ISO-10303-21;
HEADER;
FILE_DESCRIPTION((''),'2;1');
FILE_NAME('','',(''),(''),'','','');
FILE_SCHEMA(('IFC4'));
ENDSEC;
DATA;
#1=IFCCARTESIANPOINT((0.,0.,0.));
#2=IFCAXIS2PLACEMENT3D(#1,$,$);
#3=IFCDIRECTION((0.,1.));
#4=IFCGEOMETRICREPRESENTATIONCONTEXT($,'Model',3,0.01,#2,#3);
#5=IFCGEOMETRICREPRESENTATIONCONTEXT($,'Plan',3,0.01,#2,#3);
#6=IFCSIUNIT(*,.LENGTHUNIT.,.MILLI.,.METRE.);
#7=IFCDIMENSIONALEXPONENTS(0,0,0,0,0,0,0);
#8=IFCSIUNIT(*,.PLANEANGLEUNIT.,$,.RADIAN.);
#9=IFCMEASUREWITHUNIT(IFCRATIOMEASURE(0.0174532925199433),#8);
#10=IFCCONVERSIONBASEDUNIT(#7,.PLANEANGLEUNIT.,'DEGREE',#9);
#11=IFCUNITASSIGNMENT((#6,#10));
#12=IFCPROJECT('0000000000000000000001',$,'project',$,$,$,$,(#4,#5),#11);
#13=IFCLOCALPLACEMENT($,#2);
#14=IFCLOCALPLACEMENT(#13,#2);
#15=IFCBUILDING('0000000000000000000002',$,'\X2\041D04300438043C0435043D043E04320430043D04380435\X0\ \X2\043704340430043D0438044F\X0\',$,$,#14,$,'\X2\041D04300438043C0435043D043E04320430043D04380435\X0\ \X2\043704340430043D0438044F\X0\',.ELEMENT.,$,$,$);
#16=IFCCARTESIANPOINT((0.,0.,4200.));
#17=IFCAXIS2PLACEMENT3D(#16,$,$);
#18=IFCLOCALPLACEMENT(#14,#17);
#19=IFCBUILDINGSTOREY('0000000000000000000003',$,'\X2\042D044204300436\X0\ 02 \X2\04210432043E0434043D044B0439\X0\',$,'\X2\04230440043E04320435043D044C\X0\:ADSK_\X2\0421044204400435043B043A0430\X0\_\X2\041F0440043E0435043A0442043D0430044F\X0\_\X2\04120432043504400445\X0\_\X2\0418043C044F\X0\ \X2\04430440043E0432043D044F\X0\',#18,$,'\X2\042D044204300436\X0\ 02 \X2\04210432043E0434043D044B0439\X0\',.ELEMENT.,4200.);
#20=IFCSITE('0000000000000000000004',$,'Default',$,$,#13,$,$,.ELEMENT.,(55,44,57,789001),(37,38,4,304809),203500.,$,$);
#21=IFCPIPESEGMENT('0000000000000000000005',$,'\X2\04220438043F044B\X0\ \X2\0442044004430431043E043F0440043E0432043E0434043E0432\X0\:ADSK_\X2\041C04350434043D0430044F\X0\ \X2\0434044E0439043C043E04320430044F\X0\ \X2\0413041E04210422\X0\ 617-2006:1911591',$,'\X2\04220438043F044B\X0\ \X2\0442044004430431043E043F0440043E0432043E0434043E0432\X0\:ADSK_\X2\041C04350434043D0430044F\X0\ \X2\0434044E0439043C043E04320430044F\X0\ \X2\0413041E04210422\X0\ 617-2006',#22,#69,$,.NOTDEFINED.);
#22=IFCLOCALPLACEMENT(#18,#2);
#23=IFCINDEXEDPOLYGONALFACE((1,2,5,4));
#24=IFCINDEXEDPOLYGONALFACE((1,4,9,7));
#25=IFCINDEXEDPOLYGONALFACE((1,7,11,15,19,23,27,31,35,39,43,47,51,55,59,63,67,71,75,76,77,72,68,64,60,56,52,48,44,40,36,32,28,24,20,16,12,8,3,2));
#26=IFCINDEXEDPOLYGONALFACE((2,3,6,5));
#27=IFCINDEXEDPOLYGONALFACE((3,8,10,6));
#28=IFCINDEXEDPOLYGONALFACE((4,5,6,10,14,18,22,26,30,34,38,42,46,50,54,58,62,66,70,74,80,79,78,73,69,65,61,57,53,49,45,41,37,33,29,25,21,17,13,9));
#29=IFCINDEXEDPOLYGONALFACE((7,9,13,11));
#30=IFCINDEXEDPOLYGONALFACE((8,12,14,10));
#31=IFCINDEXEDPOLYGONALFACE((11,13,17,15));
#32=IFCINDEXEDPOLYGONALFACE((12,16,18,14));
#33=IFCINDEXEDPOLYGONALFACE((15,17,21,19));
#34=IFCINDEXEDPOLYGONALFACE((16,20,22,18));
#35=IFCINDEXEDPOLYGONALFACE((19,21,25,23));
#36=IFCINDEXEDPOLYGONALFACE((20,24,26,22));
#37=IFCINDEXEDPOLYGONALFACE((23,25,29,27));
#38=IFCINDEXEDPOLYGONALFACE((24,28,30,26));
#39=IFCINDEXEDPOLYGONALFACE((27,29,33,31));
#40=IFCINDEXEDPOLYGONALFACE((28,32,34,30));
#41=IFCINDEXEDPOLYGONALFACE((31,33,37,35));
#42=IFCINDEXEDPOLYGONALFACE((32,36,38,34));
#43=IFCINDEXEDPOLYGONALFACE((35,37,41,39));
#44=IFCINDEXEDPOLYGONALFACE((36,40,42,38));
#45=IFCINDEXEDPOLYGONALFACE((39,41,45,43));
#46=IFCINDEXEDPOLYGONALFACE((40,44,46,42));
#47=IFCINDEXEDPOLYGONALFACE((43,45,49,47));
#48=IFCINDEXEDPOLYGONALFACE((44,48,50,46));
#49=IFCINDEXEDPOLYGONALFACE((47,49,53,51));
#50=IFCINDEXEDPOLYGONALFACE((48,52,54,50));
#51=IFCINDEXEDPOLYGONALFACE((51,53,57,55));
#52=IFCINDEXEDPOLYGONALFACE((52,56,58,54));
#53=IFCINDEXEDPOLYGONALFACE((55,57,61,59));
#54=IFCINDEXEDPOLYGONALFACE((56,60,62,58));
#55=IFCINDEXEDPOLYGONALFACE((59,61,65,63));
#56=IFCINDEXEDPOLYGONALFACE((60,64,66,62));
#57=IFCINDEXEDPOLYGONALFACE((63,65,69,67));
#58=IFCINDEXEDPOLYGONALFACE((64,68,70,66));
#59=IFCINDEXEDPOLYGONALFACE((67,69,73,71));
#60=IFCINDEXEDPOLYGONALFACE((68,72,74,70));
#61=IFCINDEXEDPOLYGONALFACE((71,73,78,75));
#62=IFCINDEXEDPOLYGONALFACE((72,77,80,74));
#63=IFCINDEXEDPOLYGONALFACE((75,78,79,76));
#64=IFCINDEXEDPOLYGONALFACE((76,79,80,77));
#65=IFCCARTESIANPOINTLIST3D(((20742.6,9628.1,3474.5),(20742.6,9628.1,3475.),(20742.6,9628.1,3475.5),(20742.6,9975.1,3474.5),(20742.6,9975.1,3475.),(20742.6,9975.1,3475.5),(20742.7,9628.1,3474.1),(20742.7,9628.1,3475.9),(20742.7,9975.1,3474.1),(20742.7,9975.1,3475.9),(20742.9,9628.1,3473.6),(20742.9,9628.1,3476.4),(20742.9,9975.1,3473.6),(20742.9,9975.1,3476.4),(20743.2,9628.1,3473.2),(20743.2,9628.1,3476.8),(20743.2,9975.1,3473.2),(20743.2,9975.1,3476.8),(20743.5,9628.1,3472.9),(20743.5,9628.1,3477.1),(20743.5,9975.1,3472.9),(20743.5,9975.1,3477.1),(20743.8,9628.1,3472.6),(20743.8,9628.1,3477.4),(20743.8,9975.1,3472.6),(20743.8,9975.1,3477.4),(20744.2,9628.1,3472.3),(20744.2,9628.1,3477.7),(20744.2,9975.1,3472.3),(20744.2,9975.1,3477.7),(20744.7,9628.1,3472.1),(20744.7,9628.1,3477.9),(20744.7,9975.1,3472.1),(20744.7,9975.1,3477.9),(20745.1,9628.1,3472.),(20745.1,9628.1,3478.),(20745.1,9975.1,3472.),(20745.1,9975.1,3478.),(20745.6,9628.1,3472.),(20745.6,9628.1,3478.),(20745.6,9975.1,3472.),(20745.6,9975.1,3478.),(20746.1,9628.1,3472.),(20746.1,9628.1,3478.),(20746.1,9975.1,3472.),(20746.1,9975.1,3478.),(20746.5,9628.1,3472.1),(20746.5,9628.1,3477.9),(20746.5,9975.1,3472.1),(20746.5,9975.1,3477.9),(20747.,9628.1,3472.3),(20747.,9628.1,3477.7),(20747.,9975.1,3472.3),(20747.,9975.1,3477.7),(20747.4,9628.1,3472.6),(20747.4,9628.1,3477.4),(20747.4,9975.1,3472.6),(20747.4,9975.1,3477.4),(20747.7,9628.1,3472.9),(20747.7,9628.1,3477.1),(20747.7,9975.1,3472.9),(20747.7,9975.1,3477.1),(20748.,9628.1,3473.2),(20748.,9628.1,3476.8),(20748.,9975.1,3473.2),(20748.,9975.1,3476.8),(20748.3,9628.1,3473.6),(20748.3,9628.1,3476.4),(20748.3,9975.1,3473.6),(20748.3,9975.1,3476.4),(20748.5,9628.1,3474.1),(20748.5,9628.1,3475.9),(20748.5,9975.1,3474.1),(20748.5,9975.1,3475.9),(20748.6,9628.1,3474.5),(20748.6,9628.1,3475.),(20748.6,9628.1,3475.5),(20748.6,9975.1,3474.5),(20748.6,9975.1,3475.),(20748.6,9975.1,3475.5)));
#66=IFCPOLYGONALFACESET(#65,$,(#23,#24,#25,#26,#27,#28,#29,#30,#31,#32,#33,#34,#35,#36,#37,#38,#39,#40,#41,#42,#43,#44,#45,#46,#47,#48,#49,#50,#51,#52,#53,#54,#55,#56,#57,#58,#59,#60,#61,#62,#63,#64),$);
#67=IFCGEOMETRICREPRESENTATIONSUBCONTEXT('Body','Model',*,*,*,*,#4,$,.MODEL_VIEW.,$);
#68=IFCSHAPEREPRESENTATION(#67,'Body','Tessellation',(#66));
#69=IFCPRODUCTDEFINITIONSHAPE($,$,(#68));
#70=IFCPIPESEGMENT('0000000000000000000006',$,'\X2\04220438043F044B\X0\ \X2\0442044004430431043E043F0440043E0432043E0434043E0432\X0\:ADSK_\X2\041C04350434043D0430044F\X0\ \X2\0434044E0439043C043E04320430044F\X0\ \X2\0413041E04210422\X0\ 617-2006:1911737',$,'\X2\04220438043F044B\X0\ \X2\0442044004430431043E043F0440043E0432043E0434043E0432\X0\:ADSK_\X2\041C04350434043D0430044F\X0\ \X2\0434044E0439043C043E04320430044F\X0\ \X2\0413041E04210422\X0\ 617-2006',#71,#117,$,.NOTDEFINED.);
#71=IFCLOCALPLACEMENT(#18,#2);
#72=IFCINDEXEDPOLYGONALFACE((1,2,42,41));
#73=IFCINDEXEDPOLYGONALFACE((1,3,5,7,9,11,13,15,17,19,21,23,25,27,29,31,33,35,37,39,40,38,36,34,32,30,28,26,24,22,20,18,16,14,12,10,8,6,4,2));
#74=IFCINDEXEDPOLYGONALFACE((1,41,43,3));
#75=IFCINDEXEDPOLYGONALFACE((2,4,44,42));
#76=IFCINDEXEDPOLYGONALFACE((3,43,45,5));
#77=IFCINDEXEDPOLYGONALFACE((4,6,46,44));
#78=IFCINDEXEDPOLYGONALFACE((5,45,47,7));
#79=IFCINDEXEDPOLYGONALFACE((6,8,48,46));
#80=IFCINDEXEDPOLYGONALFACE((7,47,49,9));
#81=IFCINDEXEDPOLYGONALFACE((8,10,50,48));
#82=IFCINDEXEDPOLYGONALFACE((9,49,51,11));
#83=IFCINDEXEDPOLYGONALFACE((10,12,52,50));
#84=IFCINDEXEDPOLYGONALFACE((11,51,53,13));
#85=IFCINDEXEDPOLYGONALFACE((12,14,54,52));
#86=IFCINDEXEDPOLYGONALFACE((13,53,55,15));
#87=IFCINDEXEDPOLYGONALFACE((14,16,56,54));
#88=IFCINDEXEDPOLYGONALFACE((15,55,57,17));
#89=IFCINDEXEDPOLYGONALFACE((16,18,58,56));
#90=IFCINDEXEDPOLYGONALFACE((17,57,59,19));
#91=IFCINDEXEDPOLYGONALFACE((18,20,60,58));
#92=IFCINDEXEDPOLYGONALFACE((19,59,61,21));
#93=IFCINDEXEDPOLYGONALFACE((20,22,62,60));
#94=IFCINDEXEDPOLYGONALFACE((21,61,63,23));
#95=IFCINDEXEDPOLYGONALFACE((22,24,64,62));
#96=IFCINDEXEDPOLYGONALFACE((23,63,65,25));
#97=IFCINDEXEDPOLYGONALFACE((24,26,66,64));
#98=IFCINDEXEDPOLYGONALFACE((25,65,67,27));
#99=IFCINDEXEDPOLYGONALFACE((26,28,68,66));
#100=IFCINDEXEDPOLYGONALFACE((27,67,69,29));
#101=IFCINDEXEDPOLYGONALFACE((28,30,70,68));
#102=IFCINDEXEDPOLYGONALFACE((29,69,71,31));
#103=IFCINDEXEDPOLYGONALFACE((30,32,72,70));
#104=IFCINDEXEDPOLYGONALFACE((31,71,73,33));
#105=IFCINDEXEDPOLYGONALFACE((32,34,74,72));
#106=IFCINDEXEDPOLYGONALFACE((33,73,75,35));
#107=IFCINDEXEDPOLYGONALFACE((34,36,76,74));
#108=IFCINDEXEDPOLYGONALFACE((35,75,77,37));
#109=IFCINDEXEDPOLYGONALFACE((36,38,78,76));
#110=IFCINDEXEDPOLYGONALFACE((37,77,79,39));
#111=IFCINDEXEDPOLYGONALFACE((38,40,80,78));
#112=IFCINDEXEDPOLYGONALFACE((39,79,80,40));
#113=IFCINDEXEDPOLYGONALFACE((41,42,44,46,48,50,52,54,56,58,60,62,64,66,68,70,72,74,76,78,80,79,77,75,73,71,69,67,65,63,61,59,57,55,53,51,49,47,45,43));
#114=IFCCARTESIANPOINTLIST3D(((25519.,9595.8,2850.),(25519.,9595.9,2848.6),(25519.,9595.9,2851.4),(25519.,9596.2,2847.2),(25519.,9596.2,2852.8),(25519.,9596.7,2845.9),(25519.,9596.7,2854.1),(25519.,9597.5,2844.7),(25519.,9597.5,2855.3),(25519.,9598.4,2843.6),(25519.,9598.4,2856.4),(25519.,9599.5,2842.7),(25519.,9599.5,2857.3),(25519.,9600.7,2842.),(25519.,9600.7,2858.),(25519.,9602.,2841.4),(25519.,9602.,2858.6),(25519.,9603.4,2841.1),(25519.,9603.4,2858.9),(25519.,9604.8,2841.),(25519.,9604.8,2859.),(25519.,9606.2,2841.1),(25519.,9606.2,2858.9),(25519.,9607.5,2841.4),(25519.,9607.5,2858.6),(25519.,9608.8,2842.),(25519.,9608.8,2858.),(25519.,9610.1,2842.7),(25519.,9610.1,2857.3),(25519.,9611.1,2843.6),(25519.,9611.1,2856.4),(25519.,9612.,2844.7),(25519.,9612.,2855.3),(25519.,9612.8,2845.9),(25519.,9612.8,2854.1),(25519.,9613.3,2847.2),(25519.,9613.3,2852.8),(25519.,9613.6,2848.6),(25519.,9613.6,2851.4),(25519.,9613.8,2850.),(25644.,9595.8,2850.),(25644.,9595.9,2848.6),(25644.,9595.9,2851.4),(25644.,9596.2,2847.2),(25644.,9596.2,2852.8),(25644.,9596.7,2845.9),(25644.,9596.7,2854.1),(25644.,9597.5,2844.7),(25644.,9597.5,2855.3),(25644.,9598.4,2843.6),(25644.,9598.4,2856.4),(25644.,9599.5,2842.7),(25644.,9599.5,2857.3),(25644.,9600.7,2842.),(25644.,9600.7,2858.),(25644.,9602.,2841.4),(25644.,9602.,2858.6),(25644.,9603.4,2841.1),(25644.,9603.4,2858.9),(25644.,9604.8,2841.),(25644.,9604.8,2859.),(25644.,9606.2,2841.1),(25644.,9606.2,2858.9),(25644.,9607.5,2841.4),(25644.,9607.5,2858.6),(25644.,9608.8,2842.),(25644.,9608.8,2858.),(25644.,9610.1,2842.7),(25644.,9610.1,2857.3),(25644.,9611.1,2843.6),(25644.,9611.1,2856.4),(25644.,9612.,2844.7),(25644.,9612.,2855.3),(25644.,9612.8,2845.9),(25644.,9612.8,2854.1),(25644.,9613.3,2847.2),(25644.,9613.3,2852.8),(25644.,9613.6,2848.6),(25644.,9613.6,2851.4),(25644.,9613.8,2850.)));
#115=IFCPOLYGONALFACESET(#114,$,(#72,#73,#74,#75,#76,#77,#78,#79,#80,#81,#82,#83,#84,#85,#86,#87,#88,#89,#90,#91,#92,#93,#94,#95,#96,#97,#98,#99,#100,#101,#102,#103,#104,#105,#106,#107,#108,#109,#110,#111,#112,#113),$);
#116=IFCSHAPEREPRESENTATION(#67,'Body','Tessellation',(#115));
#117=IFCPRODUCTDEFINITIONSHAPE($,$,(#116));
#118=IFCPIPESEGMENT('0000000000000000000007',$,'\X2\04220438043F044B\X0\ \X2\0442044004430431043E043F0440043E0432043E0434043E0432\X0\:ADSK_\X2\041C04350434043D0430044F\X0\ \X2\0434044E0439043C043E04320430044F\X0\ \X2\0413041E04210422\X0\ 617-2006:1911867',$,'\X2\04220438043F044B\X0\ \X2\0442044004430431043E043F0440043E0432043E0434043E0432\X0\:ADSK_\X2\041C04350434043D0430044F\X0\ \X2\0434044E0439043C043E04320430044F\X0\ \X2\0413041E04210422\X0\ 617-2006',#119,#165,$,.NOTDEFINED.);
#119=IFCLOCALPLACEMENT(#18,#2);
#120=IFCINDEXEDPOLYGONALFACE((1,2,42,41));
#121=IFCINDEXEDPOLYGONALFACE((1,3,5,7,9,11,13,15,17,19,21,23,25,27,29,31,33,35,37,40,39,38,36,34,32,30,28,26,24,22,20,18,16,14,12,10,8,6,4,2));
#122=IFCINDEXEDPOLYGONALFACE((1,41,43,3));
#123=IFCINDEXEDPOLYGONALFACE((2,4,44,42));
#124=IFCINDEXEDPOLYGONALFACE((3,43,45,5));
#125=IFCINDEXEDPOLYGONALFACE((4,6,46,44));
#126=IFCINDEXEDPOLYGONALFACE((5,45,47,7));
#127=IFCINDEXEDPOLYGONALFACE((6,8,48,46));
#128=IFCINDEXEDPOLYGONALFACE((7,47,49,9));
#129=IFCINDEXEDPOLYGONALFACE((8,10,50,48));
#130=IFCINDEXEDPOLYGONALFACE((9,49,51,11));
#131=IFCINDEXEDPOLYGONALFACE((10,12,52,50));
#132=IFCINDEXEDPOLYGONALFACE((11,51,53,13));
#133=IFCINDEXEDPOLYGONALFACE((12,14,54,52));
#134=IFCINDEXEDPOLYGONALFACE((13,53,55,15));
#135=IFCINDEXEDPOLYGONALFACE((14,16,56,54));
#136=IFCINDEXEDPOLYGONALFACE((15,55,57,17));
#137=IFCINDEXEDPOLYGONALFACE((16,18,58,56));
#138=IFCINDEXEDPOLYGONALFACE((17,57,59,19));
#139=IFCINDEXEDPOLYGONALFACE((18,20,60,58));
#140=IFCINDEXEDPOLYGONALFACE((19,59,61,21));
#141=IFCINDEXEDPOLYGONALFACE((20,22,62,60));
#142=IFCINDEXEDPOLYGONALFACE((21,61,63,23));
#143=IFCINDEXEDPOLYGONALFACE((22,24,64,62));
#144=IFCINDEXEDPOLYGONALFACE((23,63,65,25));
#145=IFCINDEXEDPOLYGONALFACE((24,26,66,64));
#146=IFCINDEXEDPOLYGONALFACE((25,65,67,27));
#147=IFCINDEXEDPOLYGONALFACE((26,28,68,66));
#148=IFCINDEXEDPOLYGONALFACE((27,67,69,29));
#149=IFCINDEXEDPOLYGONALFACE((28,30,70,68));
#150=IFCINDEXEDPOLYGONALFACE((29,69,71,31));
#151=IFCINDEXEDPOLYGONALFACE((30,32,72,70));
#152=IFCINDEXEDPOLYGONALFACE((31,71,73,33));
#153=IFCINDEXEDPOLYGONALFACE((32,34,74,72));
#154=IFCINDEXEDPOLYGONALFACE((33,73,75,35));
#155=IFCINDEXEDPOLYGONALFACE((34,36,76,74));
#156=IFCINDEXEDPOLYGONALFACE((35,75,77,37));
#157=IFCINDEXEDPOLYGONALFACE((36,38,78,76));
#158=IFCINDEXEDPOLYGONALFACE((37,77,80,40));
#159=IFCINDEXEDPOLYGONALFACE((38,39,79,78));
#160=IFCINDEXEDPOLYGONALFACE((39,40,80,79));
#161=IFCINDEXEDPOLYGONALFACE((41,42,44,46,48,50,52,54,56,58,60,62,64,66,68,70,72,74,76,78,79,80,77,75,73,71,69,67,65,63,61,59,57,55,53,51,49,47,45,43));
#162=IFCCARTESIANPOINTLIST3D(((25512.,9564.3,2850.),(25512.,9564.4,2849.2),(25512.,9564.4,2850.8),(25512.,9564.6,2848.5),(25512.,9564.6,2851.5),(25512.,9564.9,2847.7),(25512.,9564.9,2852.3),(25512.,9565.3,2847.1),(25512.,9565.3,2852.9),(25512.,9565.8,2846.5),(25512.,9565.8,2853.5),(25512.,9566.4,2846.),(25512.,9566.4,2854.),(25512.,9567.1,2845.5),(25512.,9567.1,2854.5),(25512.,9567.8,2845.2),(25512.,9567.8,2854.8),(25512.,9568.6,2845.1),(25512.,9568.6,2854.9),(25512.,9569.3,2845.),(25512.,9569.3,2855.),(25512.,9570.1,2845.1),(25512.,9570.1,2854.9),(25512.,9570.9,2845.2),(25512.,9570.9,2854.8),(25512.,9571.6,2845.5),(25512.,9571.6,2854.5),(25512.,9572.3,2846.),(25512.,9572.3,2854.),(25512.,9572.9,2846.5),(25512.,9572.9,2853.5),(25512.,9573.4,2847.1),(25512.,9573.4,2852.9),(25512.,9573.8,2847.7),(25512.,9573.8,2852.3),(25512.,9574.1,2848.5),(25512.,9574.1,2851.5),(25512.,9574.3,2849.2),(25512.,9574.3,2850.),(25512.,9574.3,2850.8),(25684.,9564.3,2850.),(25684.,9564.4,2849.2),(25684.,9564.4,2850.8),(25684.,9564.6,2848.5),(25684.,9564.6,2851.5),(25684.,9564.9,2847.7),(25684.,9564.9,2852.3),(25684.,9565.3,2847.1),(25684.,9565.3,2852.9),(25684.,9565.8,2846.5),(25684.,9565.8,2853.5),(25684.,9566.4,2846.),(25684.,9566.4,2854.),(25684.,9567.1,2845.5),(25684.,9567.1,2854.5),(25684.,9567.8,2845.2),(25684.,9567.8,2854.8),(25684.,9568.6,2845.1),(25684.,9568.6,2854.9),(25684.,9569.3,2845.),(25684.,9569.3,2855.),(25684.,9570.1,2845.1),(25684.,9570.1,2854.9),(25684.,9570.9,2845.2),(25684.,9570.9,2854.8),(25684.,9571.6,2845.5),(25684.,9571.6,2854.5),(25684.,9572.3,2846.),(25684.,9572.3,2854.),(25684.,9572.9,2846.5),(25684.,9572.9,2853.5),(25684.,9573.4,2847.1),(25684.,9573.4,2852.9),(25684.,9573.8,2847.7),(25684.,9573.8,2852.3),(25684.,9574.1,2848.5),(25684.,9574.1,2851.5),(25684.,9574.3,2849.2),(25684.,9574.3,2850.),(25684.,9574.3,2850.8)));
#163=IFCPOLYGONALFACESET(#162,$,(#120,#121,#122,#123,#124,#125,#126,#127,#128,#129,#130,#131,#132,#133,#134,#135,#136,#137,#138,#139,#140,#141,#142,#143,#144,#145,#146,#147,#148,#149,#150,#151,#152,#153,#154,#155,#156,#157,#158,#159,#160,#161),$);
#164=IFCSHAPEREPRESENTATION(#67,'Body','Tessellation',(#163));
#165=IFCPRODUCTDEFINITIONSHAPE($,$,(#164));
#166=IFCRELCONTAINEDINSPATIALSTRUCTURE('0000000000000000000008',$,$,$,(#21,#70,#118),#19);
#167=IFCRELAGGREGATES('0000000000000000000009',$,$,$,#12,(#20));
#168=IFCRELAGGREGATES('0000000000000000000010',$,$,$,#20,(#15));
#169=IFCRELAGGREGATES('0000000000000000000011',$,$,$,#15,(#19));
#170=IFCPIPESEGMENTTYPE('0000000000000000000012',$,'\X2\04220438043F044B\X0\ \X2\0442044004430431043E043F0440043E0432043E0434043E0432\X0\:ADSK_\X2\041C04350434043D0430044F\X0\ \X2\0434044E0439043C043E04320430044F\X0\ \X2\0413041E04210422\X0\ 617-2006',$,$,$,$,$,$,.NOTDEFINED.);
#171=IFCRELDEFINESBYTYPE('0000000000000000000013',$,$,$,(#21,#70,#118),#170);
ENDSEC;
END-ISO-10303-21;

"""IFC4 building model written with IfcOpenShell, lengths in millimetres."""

from ifc_helpers import new_model, entity, si_unit, converted_unit, direction, frame, origin, place, context, subcontext, project, spatial, indexed_curve, outline, extrude, type_object, element, save


model = new_model("IFC4")

# Units and contexts
model_context = context("Model", 3, precision=0.01, world=origin(), true_north=direction((0.0, 1.0)))
plan_context = context("Plan", 3, precision=0.01, world=origin(), true_north=direction((0.0, 1.0)))
body_context = subcontext(model_context, "Body", "Model", "MODEL_VIEW")
ifc_project = project(units=[si_unit("LENGTHUNIT", "METRE", prefix="MILLI"), converted_unit("PLANEANGLEUNIT", "DEGREE", entity("IfcRatioMeasure", 0.0174532925199433), si_unit("PLANEANGLEUNIT", "RADIAN"), dimensions=[0, 0, 0, 0, 0, 0, 0])], contexts=[model_context, plan_context])

# Site, building, storey
site_placement = place(None, origin())
site = spatial("IfcSite", under=ifc_project, at=site_placement, Name="Default", CompositionType="ELEMENT", RefLatitude=(55, 44, 57, 789001), RefLongitude=(37, 38, 4, 304809), RefElevation=203500.0)
building_placement = place(site_placement, origin())
building = spatial("IfcBuilding", under=site, at=building_placement, Name="Наименование здания", LongName="Наименование здания", CompositionType="ELEMENT")
storey_placement = place(building_placement, frame((0.0, 0.0, 4200.0)))
storey = spatial("IfcBuildingStorey", under=building, at=storey_placement, Name="Этаж 02 Сводный", ObjectType="Уровень:ADSK_Стрелка_Проектная_Вверх_Имя уровня", LongName="Этаж 02 Сводный", CompositionType="ELEMENT", Elevation=4200.0)

# Pipe segments
pipe_segment_type_1 = type_object("IfcPipeSegmentType", Name="Типы трубопроводов:ADSK_Медная дюймовая ГОСТ 617-2006", PredefinedType="NOTDEFINED")
placement = place(storey_placement, origin())
element("IfcPipeSegment", 1, at=placement, inside=storey, type_object=pipe_segment_type_1, Name="Типы трубопроводов:ADSK_Медная дюймовая ГОСТ 617-2006:1911591", ObjectType="Типы трубопроводов:ADSK_Медная дюймовая ГОСТ 617-2006", PredefinedType="NOTDEFINED", context=body_context, shape_type="SweptSolid", body=[
    extrude(outline(indexed_curve([(3.0, 0.0), (3.0, 0.5), (2.9, 0.9), (2.7, 1.4), (2.4, 1.8), (2.1, 2.1), (1.8, 2.4), (1.4, 2.7), (0.9, 2.9), (0.5, 3.0), (0.0, 3.0), (-0.5, 3.0), (-0.9, 2.9), (-1.4, 2.7), (-1.8, 2.4), (-2.1, 2.1), (-2.4, 1.8), (-2.7, 1.4), (-2.9, 0.9), (-3.0, 0.5), (-3.0, 0.0), (-3.0, -0.5), (-2.9, -0.9), (-2.7, -1.4), (-2.4, -1.8), (-2.1, -2.1), (-1.8, -2.4), (-1.4, -2.7), (-0.9, -2.9), (-0.5, -3.0), (0.0, -3.0), (0.5, -3.0), (0.9, -2.9), (1.4, -2.7), (1.8, -2.4), (2.1, -2.1), (2.4, -1.8), (2.7, -1.4), (2.9, -0.9), (3.0, -0.5), (3.0, 0.0)], self_intersect=False)), frame((20745.6, 9628.1, 3475.0), z_axis=(0.0, 1.0, 0.0), x_axis=(-1.0, 0.0, 0.0)), (0.0, 0.0, 1.0), 347.0),
])
element("IfcPipeSegment", 2, at=placement, inside=storey, type_object=pipe_segment_type_1, Name="Типы трубопроводов:ADSK_Медная дюймовая ГОСТ 617-2006:1911737", ObjectType="Типы трубопроводов:ADSK_Медная дюймовая ГОСТ 617-2006", PredefinedType="NOTDEFINED", context=body_context, shape_type="SweptSolid", body=[
    extrude(outline(indexed_curve([(9.0, 0.0), (8.9, 1.4), (8.6, 2.8), (8.0, 4.1), (7.3, 5.3), (6.4, 6.4), (5.3, 7.3), (4.1, 8.0), (2.8, 8.6), (1.4, 8.9), (0.0, 9.0), (-1.4, 8.9), (-2.8, 8.6), (-4.1, 8.0), (-5.3, 7.3), (-6.4, 6.4), (-7.3, 5.3), (-8.0, 4.1), (-8.6, 2.8), (-8.9, 1.4), (-9.0, 0.0), (-8.9, -1.4), (-8.6, -2.8), (-8.0, -4.1), (-7.3, -5.3), (-6.4, -6.4), (-5.3, -7.3), (-4.1, -8.0), (-2.8, -8.6), (-1.4, -8.9), (0.0, -9.0), (1.4, -8.9), (2.8, -8.6), (4.1, -8.0), (5.3, -7.3), (6.4, -6.4), (7.3, -5.3), (8.0, -4.1), (8.6, -2.8), (8.9, -1.4), (9.0, 0.0)], self_intersect=False)), frame((25519.0, 9604.8, 2850.0), z_axis=(1.0, 0.0, 0.0), x_axis=(0.0, -1.0, 0.0)), (0.0, 0.0, 1.0), 125.0),
])
element("IfcPipeSegment", 3, at=placement, inside=storey, type_object=pipe_segment_type_1, Name="Типы трубопроводов:ADSK_Медная дюймовая ГОСТ 617-2006:1911867", ObjectType="Типы трубопроводов:ADSK_Медная дюймовая ГОСТ 617-2006", PredefinedType="NOTDEFINED", context=body_context, shape_type="SweptSolid", body=[
    extrude(outline(indexed_curve([(5.0, 0.0), (4.9, 0.8), (4.8, 1.5), (4.5, 2.3), (4.0, 2.9), (3.5, 3.5), (2.9, 4.0), (2.3, 4.5), (1.5, 4.8), (0.8, 4.9), (0.0, 5.0), (-0.8, 4.9), (-1.5, 4.8), (-2.3, 4.5), (-2.9, 4.0), (-3.5, 3.5), (-4.0, 2.9), (-4.5, 2.3), (-4.8, 1.5), (-4.9, 0.8), (-5.0, 0.0), (-4.9, -0.8), (-4.8, -1.5), (-4.5, -2.3), (-4.0, -2.9), (-3.5, -3.5), (-2.9, -4.0), (-2.3, -4.5), (-1.5, -4.8), (-0.8, -4.9), (0.0, -5.0), (0.8, -4.9), (1.5, -4.8), (2.3, -4.5), (2.9, -4.0), (3.5, -3.5), (4.0, -2.9), (4.5, -2.3), (4.8, -1.5), (4.9, -0.8), (5.0, 0.0)], self_intersect=False)), frame((25512.0, 9569.3, 2850.0), z_axis=(1.0, 0.0, 0.0), x_axis=(0.0, -1.0, 0.0)), (0.0, 0.0, 1.0), 172.0),
])

save(model, "model.ifc")
